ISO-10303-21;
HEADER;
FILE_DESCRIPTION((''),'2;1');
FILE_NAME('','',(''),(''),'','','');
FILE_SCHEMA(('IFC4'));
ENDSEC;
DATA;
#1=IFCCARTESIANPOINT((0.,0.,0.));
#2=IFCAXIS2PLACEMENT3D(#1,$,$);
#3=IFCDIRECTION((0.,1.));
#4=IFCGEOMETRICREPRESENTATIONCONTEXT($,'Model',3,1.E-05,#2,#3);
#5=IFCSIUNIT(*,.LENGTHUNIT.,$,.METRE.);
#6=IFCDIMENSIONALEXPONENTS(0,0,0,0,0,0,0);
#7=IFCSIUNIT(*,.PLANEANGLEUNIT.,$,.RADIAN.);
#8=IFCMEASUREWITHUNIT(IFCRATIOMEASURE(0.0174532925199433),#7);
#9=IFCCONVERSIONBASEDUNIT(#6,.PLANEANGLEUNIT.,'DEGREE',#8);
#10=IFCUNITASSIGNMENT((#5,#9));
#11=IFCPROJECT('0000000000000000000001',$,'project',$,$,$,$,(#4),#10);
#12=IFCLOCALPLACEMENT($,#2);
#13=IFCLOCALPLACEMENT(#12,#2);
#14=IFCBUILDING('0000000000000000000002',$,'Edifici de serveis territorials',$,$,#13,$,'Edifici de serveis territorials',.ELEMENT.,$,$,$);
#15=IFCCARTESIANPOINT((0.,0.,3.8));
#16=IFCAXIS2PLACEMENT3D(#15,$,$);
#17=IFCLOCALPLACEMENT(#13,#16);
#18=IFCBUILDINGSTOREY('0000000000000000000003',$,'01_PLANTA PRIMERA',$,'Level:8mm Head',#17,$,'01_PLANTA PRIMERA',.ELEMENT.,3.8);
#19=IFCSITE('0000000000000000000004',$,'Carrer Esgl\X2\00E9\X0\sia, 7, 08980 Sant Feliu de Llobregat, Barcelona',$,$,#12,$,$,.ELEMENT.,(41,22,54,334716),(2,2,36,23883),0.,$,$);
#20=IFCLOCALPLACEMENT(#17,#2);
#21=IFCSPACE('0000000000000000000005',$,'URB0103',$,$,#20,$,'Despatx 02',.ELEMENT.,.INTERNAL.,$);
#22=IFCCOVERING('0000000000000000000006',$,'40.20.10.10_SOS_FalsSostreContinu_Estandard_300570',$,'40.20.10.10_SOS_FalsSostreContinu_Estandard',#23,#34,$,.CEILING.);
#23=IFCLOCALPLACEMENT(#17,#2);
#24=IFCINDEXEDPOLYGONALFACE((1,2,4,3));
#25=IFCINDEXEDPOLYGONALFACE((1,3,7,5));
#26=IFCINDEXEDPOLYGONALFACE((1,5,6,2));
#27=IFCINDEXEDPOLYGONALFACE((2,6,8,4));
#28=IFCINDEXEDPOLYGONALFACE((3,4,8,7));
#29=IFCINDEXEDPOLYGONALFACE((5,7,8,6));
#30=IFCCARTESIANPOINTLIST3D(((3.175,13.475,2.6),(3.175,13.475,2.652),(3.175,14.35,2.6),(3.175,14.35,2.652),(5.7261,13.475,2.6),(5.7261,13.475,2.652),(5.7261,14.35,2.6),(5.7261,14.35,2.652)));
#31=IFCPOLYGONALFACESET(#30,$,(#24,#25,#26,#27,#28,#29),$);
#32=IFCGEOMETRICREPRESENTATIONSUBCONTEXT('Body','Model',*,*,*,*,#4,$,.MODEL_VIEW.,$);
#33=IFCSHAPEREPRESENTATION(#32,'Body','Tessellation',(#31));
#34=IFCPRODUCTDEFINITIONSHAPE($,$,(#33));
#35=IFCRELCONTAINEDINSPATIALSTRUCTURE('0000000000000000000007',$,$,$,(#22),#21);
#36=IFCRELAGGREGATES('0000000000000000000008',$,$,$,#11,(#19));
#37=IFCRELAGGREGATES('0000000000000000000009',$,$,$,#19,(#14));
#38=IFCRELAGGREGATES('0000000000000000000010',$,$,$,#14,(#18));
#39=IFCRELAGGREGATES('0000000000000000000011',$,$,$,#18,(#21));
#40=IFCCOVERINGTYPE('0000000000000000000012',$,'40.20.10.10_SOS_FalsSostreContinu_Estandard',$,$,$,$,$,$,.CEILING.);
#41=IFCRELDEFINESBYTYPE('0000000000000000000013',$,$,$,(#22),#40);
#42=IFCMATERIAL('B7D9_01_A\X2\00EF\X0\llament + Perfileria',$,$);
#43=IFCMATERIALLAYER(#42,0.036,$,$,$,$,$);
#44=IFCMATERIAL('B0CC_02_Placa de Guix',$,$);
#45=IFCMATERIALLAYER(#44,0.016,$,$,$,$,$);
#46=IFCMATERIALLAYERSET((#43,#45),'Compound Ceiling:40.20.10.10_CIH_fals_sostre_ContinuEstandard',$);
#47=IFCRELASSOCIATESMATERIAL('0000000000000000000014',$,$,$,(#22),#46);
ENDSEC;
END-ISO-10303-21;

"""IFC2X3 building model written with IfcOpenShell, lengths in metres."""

from ifc_helpers import new_model, entity, si_unit, converted_unit, direction, frame, frame_2d, origin, place, context, subcontext, project, spatial, rectangle, extrude, material, layer, layer_set, layer_usage, type_object, element, save


model = new_model("IFC2X3")

# Units and contexts
model_context = context("Model", 3, precision=1e-05, world=origin(), true_north=direction((0.0, 1.0)))
body_context = subcontext(model_context, "Body", "Model", "MODEL_VIEW")
ifc_project = project(units=[si_unit("LENGTHUNIT", "METRE"), converted_unit("PLANEANGLEUNIT", "DEGREE", entity("IfcRatioMeasure", 0.0174532925199433), si_unit("PLANEANGLEUNIT", "RADIAN"), dimensions=[0, 0, 0, 0, 0, 0, 0])], contexts=[model_context])

# Site, building, storey
site_placement = place(None, origin())
site = spatial("IfcSite", under=ifc_project, at=site_placement, Name="Carrer Església, 7, 08980 Sant Feliu de Llobregat, Barcelona", CompositionType="ELEMENT", RefLatitude=(41, 22, 54, 334716), RefLongitude=(2, 2, 36, 23883), RefElevation=0.0)
building_placement = place(site_placement, origin())
building = spatial("IfcBuilding", under=site, at=building_placement, Name="Edifici de serveis territorials", LongName="Edifici de serveis territorials", CompositionType="ELEMENT")
storey_placement = place(building_placement, frame((0.0, 0.0, 3.8)))
storey = spatial("IfcBuildingStorey", under=building, at=storey_placement, Name="01_PLANTA PRIMERA", ObjectType="Level:8mm Head", LongName="01_PLANTA PRIMERA", CompositionType="ELEMENT", Elevation=3.8)

# Shared definitions
ifc_material_1 = material(Name="B0CC_02_Placa de Guix")
ifc_material_2 = material(Name="B7D9_01_Aïllament + Perfileria")

# Shared definitions
space_1_placement = place(storey_placement, origin())
space_1 = spatial("IfcSpace", under=storey, at=space_1_placement, Name="URB0103", LongName="Despatx 02", CompositionType="ELEMENT", InteriorOrExteriorSpace="INTERNAL")

# Covering
ifc_layer_1 = layer(ifc_material_2, 0.036)
ifc_layer_2 = layer(ifc_material_1, 0.016)
ifc_layer_set_1 = layer_set([ifc_layer_1, ifc_layer_2], Name="Compound Ceiling:40.20.10.10_CIH_fals_sostre_ContinuEstandard")
ifc_layer_usage_1 = layer_usage(ifc_layer_set_1, "AXIS3", "POSITIVE", 0.0)
covering_type_1 = type_object("IfcCoveringType", Name="40.20.10.10_SOS_FalsSostreContinu_Estandard", PredefinedType="CEILING")
covering_1_placement = place(space_1_placement, frame((3.175, 13.475, 2.6)))
element("IfcCovering", 1, at=covering_1_placement, inside=space_1, type_object=covering_type_1, material=ifc_layer_usage_1, Name="40.20.10.10_SOS_FalsSostreContinu_Estandard_300570", ObjectType="40.20.10.10_SOS_FalsSostreContinu_Estandard", PredefinedType="CEILING", context=body_context, shape_type="SweptSolid", body=[
    extrude(rectangle(XDim=2.5511, YDim=0.875, at=frame_2d((0.0, 0.0), x_axis=(1.0, 0.0))), frame((1.2755, 0.4375, 0.0)), (0.0, 0.0, 1.0), 0.052),
])

save(model, "model.ifc")
